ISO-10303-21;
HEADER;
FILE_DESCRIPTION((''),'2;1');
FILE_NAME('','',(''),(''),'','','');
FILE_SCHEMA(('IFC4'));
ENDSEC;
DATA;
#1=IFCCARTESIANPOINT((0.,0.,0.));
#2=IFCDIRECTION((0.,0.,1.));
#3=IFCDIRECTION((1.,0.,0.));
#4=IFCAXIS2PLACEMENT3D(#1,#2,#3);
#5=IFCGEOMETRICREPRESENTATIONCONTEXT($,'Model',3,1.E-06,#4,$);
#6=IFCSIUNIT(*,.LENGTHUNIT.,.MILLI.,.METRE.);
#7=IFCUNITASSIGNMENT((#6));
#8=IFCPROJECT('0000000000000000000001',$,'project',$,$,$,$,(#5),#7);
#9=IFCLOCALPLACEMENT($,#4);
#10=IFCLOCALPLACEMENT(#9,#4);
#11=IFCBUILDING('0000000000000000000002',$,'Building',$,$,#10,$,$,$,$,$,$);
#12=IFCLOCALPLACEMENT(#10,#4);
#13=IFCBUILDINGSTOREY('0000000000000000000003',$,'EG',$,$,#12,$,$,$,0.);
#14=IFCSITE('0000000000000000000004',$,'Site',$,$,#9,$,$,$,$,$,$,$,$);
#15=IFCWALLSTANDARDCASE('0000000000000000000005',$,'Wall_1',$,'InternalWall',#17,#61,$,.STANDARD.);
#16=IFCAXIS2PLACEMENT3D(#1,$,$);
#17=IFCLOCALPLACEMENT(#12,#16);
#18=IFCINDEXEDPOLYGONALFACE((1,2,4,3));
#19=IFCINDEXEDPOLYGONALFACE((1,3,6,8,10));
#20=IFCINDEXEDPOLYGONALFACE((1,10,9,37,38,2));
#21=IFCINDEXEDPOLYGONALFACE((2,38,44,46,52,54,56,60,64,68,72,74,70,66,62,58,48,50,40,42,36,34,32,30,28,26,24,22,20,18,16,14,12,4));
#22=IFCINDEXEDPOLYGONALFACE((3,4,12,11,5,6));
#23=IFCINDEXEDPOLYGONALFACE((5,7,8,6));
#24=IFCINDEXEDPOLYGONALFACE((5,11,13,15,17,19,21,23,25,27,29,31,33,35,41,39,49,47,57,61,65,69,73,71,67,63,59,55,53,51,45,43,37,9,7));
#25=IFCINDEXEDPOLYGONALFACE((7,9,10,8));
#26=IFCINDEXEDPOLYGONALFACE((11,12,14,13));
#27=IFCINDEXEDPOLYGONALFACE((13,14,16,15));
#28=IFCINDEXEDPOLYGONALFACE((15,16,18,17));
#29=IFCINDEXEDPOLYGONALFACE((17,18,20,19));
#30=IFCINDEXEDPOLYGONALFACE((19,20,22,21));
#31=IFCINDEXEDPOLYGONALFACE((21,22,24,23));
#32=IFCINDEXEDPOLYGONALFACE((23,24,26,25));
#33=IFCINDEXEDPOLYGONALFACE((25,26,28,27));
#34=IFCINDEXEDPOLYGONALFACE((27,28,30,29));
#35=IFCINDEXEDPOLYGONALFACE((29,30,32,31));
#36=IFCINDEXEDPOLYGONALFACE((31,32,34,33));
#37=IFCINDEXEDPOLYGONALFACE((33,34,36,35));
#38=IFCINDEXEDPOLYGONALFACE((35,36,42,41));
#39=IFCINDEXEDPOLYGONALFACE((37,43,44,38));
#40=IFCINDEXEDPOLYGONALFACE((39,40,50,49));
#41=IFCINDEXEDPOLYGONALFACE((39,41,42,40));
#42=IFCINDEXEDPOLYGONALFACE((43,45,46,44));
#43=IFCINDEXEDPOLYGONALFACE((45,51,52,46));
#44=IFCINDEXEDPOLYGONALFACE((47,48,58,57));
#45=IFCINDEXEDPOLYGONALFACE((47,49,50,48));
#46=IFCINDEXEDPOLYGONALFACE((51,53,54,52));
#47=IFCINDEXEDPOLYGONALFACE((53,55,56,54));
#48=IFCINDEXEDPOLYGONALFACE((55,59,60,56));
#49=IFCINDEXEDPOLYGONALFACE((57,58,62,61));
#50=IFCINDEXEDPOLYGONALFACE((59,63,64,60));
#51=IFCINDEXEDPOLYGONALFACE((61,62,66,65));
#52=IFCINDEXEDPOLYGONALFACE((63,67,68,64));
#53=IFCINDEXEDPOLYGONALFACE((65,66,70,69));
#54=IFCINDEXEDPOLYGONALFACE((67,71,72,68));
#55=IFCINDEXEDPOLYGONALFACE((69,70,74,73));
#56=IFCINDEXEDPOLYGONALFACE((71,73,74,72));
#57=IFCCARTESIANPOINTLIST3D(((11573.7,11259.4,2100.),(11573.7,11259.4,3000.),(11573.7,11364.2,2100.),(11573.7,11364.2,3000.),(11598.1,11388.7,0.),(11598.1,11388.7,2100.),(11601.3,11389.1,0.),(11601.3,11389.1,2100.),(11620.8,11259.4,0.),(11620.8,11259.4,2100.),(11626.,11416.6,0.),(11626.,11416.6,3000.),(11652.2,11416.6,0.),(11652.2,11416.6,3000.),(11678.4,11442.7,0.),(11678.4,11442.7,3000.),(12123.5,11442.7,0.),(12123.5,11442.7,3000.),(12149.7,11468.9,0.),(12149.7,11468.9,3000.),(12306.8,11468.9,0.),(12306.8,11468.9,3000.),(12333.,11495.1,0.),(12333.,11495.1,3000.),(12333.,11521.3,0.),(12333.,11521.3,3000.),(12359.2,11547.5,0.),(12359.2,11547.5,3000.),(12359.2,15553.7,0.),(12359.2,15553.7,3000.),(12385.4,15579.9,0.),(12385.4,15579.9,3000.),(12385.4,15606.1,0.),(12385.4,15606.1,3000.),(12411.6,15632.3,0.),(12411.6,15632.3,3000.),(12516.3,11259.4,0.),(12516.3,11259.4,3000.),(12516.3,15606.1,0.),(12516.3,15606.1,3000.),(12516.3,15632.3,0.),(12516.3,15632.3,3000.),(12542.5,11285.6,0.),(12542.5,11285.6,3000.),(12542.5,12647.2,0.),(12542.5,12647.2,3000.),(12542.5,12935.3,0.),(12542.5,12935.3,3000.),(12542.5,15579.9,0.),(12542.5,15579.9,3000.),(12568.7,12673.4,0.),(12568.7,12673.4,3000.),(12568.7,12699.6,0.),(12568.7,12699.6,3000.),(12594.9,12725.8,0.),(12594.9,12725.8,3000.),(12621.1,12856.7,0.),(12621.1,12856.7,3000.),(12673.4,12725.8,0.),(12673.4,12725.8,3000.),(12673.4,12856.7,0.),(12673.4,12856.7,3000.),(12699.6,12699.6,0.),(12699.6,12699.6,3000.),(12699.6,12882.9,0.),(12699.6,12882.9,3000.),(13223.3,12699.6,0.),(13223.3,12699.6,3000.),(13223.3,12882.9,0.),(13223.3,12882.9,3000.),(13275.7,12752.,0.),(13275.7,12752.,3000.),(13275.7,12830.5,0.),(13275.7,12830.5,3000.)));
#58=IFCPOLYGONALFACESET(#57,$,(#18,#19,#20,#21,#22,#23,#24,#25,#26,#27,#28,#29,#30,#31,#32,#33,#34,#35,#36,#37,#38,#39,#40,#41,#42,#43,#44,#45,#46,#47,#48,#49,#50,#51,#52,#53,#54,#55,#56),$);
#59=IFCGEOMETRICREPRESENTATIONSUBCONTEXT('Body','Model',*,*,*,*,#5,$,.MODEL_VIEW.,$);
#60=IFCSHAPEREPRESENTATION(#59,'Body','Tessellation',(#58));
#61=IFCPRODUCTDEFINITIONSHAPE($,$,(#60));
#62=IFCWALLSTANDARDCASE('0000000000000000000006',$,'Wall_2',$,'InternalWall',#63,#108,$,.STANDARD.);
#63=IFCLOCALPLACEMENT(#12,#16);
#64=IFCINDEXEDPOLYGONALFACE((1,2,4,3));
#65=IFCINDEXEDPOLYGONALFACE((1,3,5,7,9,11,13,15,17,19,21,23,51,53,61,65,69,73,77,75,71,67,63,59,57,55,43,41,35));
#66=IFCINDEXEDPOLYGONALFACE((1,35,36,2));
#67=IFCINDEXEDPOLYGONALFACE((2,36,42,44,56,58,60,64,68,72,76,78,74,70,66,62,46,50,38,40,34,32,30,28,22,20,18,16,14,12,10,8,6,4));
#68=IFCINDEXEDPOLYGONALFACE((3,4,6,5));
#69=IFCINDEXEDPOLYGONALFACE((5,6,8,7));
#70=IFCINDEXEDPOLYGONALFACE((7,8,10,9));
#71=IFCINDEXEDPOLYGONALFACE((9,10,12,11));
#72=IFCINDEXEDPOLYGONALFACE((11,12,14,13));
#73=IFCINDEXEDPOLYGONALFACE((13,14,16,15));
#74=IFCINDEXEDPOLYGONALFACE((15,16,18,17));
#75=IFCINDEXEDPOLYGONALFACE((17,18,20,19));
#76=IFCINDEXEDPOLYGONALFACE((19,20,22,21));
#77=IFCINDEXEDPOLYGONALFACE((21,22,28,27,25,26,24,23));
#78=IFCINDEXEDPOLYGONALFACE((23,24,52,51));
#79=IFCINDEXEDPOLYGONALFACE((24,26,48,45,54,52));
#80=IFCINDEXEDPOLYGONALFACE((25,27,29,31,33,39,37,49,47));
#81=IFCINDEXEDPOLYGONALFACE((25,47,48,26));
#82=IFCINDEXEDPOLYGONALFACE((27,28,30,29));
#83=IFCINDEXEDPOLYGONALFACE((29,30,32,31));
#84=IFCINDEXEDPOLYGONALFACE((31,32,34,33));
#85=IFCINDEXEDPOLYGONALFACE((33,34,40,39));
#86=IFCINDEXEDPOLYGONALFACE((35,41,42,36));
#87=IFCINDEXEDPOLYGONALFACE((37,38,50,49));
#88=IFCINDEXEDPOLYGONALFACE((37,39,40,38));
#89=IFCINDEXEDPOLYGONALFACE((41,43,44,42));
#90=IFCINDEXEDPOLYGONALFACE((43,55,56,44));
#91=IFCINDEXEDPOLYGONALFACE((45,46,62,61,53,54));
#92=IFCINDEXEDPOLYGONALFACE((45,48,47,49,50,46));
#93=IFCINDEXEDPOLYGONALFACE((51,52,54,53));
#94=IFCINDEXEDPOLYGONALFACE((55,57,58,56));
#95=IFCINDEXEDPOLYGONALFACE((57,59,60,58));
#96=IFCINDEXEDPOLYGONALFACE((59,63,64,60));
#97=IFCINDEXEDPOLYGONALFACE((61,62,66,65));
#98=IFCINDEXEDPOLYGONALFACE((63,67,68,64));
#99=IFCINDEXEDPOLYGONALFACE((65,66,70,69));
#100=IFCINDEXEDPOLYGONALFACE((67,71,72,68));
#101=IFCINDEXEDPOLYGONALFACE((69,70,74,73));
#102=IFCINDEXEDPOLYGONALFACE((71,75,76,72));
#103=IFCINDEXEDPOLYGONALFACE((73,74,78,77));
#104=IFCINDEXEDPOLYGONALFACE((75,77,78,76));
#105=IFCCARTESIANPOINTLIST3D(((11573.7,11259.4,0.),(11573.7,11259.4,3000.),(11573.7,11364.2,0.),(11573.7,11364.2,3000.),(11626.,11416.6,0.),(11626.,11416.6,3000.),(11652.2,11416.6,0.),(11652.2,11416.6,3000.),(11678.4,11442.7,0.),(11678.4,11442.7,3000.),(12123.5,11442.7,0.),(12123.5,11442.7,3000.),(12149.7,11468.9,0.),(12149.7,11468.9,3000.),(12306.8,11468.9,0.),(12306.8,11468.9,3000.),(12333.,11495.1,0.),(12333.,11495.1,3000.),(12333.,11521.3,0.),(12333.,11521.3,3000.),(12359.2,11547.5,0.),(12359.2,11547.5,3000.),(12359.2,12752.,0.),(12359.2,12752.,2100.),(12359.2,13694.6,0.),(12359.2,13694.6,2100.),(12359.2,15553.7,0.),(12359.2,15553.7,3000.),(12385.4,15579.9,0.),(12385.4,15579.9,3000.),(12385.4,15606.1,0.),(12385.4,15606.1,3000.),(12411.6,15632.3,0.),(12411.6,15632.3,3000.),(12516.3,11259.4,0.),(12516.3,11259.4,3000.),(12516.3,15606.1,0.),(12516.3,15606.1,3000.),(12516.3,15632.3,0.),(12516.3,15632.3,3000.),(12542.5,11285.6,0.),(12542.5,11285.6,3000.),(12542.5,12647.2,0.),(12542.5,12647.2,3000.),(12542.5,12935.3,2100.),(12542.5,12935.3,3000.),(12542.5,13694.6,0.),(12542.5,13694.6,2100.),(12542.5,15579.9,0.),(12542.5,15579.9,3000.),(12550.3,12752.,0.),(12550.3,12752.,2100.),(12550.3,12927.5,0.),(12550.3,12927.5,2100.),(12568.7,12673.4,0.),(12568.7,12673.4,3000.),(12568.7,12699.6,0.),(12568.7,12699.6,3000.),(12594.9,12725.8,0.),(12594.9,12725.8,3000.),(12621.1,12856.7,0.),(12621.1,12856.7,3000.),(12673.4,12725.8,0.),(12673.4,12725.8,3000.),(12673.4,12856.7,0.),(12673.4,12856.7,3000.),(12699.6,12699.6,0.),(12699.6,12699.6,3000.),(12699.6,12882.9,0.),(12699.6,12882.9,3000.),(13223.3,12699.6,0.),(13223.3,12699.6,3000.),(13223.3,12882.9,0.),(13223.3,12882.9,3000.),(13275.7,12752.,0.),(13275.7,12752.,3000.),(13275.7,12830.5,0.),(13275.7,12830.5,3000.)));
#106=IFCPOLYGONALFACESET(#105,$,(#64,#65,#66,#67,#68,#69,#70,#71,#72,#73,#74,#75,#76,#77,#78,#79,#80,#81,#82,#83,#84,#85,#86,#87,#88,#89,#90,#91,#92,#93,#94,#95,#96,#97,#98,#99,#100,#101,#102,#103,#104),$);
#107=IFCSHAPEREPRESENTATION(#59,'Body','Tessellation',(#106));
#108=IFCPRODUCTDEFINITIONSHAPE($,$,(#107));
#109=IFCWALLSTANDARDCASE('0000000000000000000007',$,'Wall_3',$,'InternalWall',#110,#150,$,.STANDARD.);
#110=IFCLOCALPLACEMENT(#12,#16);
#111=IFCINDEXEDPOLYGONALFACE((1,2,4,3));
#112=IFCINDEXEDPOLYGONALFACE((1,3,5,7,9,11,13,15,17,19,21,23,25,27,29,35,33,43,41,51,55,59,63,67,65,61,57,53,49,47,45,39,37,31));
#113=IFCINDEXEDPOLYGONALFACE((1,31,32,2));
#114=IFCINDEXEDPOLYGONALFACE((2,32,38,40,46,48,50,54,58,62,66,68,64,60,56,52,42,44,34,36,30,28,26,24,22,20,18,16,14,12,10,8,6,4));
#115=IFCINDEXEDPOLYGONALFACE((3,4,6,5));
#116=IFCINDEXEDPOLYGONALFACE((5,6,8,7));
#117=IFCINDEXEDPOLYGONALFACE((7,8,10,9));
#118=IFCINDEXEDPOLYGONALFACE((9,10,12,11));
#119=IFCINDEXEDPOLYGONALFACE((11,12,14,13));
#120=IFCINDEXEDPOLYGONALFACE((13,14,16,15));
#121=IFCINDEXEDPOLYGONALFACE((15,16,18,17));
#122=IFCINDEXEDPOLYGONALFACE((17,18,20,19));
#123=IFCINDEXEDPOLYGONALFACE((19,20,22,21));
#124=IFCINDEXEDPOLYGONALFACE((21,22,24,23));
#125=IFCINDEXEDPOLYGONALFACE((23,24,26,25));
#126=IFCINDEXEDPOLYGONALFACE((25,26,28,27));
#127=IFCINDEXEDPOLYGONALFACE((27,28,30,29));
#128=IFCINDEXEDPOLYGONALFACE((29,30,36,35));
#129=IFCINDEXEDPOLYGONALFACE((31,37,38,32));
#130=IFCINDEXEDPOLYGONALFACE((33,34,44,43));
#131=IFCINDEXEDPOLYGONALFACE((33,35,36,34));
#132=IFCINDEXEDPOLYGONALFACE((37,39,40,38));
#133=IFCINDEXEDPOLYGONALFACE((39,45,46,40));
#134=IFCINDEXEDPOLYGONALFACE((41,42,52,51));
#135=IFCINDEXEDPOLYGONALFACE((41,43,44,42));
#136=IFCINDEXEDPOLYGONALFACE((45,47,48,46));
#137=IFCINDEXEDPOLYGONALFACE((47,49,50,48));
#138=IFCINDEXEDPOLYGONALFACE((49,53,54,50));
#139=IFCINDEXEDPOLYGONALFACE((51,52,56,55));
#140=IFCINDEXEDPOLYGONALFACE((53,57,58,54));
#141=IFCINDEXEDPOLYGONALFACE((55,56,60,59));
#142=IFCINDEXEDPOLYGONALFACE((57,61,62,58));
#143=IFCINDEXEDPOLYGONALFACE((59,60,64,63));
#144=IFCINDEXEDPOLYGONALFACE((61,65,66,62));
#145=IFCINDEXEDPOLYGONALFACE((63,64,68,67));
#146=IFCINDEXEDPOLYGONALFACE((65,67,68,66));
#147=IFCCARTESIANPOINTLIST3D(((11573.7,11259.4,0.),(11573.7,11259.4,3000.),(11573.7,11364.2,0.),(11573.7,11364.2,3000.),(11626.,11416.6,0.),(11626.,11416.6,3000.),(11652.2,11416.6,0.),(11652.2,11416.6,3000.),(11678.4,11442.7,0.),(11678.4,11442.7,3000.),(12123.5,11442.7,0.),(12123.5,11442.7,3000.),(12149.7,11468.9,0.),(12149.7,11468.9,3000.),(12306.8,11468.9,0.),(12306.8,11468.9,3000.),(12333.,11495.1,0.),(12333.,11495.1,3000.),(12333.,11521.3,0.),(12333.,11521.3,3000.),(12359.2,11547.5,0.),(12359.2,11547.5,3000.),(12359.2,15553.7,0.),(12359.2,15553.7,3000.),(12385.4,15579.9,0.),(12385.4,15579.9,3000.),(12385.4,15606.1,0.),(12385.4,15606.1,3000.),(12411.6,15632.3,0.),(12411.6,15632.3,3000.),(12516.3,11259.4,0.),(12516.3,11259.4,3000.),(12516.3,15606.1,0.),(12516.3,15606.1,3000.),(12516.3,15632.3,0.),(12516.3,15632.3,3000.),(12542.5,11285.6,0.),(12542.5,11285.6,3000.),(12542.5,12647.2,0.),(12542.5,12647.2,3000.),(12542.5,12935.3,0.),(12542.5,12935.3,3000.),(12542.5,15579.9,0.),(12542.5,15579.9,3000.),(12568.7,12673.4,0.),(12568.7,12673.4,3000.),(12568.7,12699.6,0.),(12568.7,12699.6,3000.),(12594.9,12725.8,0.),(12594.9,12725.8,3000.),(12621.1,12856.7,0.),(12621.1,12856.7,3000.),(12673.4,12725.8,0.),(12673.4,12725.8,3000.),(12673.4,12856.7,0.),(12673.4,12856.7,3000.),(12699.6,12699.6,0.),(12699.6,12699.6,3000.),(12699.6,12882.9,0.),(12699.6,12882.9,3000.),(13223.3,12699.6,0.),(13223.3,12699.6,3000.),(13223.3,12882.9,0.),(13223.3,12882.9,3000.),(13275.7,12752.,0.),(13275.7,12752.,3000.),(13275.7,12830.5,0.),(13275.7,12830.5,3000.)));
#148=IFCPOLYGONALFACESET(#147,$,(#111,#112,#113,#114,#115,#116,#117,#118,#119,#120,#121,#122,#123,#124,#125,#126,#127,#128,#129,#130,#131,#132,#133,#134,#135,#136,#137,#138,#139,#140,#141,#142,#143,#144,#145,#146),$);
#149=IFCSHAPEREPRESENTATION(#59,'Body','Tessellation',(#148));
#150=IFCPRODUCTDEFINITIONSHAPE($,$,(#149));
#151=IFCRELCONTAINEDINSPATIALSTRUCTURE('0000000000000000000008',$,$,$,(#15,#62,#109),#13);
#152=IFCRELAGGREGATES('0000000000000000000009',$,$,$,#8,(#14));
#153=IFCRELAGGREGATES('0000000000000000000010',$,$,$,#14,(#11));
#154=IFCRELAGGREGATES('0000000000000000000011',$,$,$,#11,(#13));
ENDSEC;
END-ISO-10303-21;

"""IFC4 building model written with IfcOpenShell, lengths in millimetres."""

from ifc_helpers import new_model, si_unit, frame, origin_with_axes, place, context, subcontext, project, spatial, polyline, rectangle, outline, extrude, element, save


model = new_model("IFC4")

# Units and contexts
model_context = context("Model", 3, precision=1e-06, world=origin_with_axes())
body_context = subcontext(model_context, "Body", "Model", "MODEL_VIEW")
ifc_project = project(units=[si_unit("LENGTHUNIT", "METRE", prefix="MILLI")], contexts=[model_context])

# Site, building, storey
site_placement = place(None, origin_with_axes())
site = spatial("IfcSite", under=ifc_project, at=site_placement, Name="Site")
building_placement = place(site_placement, origin_with_axes())
building = spatial("IfcBuilding", under=site, at=building_placement, Name="Building")
storey_placement = place(building_placement, origin_with_axes())
storey = spatial("IfcBuildingStorey", under=building, at=storey_placement, Name="EG", Elevation=0.0)

# Walls, openings
wall_1_placement = place(storey_placement, origin_with_axes())
wall_1 = element("IfcWallStandardCase", 1, at=wall_1_placement, inside=storey, Name="Wall_1", ObjectType="InternalWall", PredefinedType="STANDARD", context=body_context, shape_type="SweptSolid", body=[
    extrude(outline(polyline([(11573.7, 11259.4, 0.0), (11573.7, 11364.2, 0.0), (11626.0, 11416.6, 0.0), (11652.2, 11416.6, 0.0), (11678.4, 11442.7, 0.0), (12123.5, 11442.7, 0.0), (12149.7, 11468.9, 0.0), (12306.8, 11468.9, 0.0), (12333.0, 11495.1, 0.0), (12333.0, 11521.3, 0.0), (12359.2, 11547.5, 0.0), (12359.2, 15553.7, 0.0), (12385.4, 15579.9, 0.0), (12385.4, 15606.1, 0.0), (12411.6, 15632.3, 0.0), (12516.3, 15632.3, 0.0), (12516.3, 15606.1, 0.0), (12542.5, 15579.9, 0.0), (12542.5, 12935.3, 0.0), (12621.1, 12856.7, 0.0), (12673.4, 12856.7, 0.0), (12699.6, 12882.9, 0.0), (13223.3, 12882.9, 0.0), (13275.7, 12830.5, 0.0), (13275.7, 12752.0, 0.0), (13223.3, 12699.6, 0.0), (12699.6, 12699.6, 0.0), (12673.4, 12725.8, 0.0), (12594.9, 12725.8, 0.0), (12568.7, 12699.6, 0.0), (12568.7, 12673.4, 0.0), (12542.5, 12647.2, 0.0), (12542.5, 11285.6, 0.0), (12516.3, 11259.4, 0.0), (11573.7, 11259.4, 0.0)])), origin_with_axes(), (0.0, 0.0, 1.0), 3000.0),
])
opening_1_placement = place(wall_1_placement, origin_with_axes())
element("IfcOpeningElement", 2, at=opening_1_placement, inside=storey, cuts=wall_1, context=body_context, shape_type="SweptSolid", body=[
    extrude(rectangle(XDim=905.0, YDim=240.0), frame((11171.6, 11203.3, 0.0), z_axis=(0.0, 0.0, 1.0), x_axis=(-0.988936, -0.14834, 0.0)), (0.0, 0.0, 1.0), 2100.0),
])
wall_2_placement = place(storey_placement, origin_with_axes())
wall_2 = element("IfcWallStandardCase", 3, at=wall_2_placement, inside=storey, Name="Wall_2", ObjectType="InternalWall", PredefinedType="STANDARD", context=body_context, shape_type="SweptSolid", body=[
    extrude(outline(polyline([(11573.7, 11259.4, 0.0), (11573.7, 11364.2, 0.0), (11626.0, 11416.6, 0.0), (11652.2, 11416.6, 0.0), (11678.4, 11442.7, 0.0), (12123.5, 11442.7, 0.0), (12149.7, 11468.9, 0.0), (12306.8, 11468.9, 0.0), (12333.0, 11495.1, 0.0), (12333.0, 11521.3, 0.0), (12359.2, 11547.5, 0.0), (12359.2, 15553.7, 0.0), (12385.4, 15579.9, 0.0), (12385.4, 15606.1, 0.0), (12411.6, 15632.3, 0.0), (12516.3, 15632.3, 0.0), (12516.3, 15606.1, 0.0), (12542.5, 15579.9, 0.0), (12542.5, 12935.3, 0.0), (12621.1, 12856.7, 0.0), (12673.4, 12856.7, 0.0), (12699.6, 12882.9, 0.0), (13223.3, 12882.9, 0.0), (13275.7, 12830.5, 0.0), (13275.7, 12752.0, 0.0), (13223.3, 12699.6, 0.0), (12699.6, 12699.6, 0.0), (12673.4, 12725.8, 0.0), (12594.9, 12725.8, 0.0), (12568.7, 12699.6, 0.0), (12568.7, 12673.4, 0.0), (12542.5, 12647.2, 0.0), (12542.5, 11285.6, 0.0), (12516.3, 11259.4, 0.0), (11573.7, 11259.4, 0.0)])), origin_with_axes(), (0.0, 0.0, 1.0), 3000.0),
])
opening_2_placement = place(wall_2_placement, origin_with_axes())
element("IfcOpeningElement", 4, at=opening_2_placement, inside=storey, cuts=wall_2, context=body_context, shape_type="SweptSolid", body=[
    extrude(rectangle(XDim=942.7, YDim=240.0), frame((12430.3, 13223.3, 0.0), z_axis=(0.0, 0.0, 1.0), x_axis=(0.0, -1.0, 0.0)), (0.0, 0.0, 1.0), 2100.0),
])

# Wall
for number, where, z_axis, x_axis, name in (
    (5, (0.0, 0.0, 0.0), (0.0, 0.0, 1.0), (1.0, 0.0, 0.0), "Wall_3"),
):
    element("IfcWallStandardCase", number, at=place(storey_placement, frame(where, z_axis=z_axis, x_axis=x_axis)), inside=storey, Name=name, ObjectType="InternalWall", PredefinedType="STANDARD", context=body_context, shape_type="SweptSolid", body=[
        extrude(outline(polyline([(11573.7, 11259.4, 0.0), (11573.7, 11364.2, 0.0), (11626.0, 11416.6, 0.0), (11652.2, 11416.6, 0.0), (11678.4, 11442.7, 0.0), (12123.5, 11442.7, 0.0), (12149.7, 11468.9, 0.0), (12306.8, 11468.9, 0.0), (12333.0, 11495.1, 0.0), (12333.0, 11521.3, 0.0), (12359.2, 11547.5, 0.0), (12359.2, 15553.7, 0.0), (12385.4, 15579.9, 0.0), (12385.4, 15606.1, 0.0), (12411.6, 15632.3, 0.0), (12516.3, 15632.3, 0.0), (12516.3, 15606.1, 0.0), (12542.5, 15579.9, 0.0), (12542.5, 12935.3, 0.0), (12621.1, 12856.7, 0.0), (12673.4, 12856.7, 0.0), (12699.6, 12882.9, 0.0), (13223.3, 12882.9, 0.0), (13275.7, 12830.5, 0.0), (13275.7, 12752.0, 0.0), (13223.3, 12699.6, 0.0), (12699.6, 12699.6, 0.0), (12673.4, 12725.8, 0.0), (12594.9, 12725.8, 0.0), (12568.7, 12699.6, 0.0), (12568.7, 12673.4, 0.0), (12542.5, 12647.2, 0.0), (12542.5, 11285.6, 0.0), (12516.3, 11259.4, 0.0), (11573.7, 11259.4, 0.0)])), origin_with_axes(), (0.0, 0.0, 1.0), 3000.0),
    ])

save(model, "model.ifc")
